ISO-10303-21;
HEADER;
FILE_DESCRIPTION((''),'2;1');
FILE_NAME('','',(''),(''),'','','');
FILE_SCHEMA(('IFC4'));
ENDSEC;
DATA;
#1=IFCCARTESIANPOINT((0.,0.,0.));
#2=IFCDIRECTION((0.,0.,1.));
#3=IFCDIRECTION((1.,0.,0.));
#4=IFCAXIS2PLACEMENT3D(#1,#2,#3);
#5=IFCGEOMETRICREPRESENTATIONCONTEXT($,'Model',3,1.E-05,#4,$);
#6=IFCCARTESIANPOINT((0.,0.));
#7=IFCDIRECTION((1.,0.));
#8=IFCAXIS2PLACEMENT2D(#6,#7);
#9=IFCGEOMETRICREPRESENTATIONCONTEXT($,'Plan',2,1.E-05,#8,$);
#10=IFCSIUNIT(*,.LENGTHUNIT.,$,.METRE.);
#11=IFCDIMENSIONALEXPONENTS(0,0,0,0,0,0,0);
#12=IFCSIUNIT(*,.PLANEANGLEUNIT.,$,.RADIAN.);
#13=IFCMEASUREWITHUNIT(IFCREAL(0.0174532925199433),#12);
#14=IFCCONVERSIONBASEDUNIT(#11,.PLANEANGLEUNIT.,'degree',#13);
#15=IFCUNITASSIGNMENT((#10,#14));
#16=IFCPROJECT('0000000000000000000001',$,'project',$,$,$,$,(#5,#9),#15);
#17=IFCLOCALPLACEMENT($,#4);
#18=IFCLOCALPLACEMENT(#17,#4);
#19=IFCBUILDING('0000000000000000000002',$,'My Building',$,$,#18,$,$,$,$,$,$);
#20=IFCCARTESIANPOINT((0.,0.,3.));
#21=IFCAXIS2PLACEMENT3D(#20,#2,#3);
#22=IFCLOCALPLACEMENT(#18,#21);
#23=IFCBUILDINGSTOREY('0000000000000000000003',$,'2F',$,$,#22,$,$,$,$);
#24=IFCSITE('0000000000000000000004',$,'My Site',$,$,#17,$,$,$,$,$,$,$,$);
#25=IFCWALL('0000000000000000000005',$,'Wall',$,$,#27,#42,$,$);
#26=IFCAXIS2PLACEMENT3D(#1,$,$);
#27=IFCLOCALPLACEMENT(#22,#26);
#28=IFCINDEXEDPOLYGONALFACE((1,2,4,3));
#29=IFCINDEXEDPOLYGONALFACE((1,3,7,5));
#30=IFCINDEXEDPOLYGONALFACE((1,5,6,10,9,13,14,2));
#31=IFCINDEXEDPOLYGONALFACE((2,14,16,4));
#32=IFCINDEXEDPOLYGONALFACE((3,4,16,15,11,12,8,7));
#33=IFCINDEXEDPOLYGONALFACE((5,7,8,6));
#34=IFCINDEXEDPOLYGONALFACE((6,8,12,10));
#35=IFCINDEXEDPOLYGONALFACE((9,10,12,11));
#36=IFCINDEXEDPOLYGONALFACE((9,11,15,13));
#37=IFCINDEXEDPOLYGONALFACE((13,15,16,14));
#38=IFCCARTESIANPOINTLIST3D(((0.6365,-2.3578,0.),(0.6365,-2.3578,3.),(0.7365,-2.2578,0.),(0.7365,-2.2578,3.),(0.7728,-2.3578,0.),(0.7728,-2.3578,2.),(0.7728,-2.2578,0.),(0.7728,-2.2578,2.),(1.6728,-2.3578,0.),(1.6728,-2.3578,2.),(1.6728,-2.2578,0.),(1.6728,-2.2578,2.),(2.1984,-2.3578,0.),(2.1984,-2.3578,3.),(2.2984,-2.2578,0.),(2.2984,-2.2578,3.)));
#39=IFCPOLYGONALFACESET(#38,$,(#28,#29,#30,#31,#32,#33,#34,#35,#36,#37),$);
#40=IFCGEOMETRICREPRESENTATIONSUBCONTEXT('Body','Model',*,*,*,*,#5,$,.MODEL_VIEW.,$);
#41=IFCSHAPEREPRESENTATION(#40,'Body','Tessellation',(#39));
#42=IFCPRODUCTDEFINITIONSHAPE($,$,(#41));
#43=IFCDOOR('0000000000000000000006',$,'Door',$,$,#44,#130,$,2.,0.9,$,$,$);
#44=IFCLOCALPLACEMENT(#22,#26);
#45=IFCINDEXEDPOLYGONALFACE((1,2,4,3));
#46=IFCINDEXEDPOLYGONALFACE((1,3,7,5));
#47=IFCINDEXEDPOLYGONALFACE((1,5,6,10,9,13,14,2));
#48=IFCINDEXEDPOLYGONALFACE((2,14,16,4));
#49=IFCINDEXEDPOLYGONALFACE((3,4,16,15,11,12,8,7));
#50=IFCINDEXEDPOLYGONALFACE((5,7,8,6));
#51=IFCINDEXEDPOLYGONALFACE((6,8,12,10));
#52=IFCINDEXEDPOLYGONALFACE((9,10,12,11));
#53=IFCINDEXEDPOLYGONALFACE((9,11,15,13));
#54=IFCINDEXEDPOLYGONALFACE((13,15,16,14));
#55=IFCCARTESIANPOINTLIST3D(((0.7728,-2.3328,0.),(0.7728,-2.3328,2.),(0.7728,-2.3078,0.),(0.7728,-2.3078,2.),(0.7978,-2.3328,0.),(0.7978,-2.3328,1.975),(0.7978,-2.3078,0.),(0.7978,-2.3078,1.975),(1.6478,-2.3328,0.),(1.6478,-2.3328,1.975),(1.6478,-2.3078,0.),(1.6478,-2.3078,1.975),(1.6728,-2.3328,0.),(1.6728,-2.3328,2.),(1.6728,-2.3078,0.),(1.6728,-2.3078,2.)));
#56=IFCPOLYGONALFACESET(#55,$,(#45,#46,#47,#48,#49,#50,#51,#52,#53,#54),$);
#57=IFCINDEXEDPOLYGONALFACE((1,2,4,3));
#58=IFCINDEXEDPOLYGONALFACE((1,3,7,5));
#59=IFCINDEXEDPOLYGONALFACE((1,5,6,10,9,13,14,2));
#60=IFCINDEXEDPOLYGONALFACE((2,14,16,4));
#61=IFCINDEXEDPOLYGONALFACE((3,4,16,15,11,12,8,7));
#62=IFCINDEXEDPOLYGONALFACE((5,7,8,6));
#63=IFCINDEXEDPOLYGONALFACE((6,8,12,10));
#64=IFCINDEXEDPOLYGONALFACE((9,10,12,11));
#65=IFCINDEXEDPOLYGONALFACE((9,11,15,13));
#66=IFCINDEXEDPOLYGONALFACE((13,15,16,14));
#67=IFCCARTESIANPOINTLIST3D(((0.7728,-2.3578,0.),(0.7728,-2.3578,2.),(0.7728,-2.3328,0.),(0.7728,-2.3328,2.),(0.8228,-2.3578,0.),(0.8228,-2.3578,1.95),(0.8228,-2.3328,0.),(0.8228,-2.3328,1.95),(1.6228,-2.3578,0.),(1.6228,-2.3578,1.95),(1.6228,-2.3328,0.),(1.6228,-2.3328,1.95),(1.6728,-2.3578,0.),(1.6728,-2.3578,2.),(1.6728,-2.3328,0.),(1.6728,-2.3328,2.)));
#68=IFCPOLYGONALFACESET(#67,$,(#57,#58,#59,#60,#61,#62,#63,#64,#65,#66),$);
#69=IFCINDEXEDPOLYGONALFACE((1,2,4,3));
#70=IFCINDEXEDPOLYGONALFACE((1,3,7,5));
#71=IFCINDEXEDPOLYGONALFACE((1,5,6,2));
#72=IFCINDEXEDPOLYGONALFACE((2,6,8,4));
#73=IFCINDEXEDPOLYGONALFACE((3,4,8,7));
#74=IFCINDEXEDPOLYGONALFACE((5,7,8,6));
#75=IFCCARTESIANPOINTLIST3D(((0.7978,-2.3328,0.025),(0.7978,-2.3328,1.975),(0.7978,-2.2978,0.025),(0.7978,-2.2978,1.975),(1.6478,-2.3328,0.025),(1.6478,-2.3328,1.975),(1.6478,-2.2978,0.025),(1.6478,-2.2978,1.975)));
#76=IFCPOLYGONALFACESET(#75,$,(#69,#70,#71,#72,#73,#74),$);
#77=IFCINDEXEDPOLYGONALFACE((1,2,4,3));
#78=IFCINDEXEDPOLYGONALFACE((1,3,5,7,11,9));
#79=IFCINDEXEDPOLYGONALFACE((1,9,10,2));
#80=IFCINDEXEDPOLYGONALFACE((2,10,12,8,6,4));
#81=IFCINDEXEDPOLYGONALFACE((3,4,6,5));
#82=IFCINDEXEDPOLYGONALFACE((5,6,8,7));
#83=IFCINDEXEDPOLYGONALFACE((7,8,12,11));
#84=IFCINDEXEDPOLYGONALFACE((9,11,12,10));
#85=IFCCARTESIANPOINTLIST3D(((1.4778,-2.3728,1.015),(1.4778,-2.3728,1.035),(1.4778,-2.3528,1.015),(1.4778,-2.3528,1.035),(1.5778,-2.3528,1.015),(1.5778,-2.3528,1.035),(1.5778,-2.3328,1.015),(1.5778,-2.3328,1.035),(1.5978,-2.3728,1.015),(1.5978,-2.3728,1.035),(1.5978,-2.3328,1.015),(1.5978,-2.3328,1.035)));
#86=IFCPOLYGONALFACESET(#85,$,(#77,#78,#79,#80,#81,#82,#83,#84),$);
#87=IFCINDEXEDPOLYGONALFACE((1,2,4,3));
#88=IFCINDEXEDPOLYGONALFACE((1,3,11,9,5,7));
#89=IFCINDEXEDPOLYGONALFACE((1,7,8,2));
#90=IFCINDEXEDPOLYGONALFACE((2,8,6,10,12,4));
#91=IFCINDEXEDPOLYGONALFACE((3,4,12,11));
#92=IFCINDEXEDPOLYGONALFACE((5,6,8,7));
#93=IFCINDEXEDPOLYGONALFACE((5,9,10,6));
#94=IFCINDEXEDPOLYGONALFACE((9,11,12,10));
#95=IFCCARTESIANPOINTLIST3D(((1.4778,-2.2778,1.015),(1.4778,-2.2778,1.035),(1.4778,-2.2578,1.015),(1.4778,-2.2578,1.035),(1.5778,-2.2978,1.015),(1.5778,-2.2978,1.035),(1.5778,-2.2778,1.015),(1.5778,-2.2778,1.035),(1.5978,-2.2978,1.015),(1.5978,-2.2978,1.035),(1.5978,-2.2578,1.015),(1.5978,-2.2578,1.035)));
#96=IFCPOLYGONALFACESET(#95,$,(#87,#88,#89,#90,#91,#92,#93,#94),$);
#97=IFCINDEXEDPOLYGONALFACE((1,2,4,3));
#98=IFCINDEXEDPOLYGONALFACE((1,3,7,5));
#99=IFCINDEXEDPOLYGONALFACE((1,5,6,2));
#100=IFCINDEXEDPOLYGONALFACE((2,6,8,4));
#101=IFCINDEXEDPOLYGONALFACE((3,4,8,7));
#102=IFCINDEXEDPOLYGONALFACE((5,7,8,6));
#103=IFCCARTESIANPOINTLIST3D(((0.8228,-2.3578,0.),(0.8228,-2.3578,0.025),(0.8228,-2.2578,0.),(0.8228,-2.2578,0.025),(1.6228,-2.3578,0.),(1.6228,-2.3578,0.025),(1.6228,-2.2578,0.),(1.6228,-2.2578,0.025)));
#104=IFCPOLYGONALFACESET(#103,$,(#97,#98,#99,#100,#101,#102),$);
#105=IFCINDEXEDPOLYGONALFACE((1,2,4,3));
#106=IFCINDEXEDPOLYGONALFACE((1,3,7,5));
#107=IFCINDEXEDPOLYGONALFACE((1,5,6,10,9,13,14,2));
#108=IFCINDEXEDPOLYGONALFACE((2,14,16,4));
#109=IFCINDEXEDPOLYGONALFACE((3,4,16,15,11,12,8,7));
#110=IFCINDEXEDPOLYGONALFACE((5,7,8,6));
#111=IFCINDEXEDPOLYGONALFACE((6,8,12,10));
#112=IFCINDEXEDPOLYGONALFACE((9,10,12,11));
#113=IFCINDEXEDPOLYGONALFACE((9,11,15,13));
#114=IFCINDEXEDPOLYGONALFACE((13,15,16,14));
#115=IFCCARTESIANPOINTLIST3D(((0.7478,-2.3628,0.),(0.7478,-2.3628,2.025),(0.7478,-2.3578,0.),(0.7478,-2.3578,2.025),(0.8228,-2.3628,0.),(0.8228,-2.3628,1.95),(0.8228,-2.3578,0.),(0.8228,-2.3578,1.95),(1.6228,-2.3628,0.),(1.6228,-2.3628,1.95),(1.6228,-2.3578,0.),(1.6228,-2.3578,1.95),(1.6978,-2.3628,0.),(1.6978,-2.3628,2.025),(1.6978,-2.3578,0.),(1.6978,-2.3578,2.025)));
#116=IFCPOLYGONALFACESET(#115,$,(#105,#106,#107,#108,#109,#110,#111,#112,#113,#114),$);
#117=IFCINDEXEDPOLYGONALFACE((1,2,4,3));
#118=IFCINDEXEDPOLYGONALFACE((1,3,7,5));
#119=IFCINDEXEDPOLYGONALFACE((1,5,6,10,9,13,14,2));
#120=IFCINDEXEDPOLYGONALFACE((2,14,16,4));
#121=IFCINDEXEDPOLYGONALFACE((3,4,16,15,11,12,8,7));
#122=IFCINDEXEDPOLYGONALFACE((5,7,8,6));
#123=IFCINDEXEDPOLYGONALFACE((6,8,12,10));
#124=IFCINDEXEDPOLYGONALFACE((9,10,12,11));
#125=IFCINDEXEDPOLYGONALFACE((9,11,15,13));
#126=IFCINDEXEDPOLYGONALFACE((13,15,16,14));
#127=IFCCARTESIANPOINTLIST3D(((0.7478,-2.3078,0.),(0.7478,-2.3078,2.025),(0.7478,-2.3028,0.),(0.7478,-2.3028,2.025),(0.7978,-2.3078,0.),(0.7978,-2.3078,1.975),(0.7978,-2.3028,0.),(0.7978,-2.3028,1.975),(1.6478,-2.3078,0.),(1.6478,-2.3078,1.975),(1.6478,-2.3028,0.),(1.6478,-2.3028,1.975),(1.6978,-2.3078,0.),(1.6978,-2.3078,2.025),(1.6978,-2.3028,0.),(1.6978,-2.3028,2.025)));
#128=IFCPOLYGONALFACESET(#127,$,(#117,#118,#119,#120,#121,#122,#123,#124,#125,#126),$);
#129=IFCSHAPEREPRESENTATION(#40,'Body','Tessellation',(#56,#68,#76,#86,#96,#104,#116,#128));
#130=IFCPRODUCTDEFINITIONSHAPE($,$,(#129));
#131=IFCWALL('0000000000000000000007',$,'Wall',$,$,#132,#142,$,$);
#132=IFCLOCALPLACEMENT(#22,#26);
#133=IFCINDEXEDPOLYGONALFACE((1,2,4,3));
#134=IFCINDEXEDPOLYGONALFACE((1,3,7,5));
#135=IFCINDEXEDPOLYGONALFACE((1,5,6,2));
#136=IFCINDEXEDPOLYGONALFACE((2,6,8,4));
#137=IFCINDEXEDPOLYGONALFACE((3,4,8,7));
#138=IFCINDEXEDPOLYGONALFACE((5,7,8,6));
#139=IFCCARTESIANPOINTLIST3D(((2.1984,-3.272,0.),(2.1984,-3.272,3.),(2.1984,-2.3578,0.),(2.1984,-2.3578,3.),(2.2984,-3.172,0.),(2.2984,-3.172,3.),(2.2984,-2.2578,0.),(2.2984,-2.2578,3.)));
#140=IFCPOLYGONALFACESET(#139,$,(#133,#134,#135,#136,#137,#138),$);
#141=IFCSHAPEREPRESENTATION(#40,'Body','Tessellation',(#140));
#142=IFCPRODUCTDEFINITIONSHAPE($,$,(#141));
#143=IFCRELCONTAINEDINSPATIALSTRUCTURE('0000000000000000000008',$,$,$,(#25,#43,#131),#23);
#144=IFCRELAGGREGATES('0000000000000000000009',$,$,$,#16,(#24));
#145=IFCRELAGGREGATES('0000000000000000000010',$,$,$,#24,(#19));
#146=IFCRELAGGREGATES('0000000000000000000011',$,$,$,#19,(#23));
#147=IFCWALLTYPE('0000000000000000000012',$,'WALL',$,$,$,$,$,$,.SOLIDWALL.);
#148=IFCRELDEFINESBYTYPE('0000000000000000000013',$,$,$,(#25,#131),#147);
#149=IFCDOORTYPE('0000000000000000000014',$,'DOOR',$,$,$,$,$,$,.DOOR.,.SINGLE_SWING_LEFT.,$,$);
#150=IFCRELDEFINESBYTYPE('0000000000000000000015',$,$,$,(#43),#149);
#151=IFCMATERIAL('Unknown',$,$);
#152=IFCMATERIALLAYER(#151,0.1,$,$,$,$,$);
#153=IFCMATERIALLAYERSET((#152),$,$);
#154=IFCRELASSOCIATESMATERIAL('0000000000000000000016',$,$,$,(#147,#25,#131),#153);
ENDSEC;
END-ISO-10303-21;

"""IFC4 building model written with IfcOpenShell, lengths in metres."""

from ifc_helpers import new_model, entity, si_unit, converted_unit, frame, origin_with_axes, origin_2d_with_axis, place, context, subcontext, project, spatial, line, indexed_curve, outline, extrude, shape, source, transform, mapped, material, layer, layer_set, layer_usage, type_object, type_shapes, element, fill, save


model = new_model("IFC4")

# Units and contexts
model_context = context("Model", 3, precision=1e-05, world=origin_with_axes())
plan_context = context("Plan", 2, precision=1e-05, world=origin_2d_with_axis())
body_context_1 = subcontext(model_context, "Body", "Model", "MODEL_VIEW")
body_context_2 = subcontext(plan_context, "Body", "Plan", "PLAN_VIEW")
ifc_project = project(units=[si_unit("LENGTHUNIT", "METRE"), converted_unit("PLANEANGLEUNIT", "degree", entity("IfcReal", 0.0174532925199433), si_unit("PLANEANGLEUNIT", "RADIAN"), dimensions=[0, 0, 0, 0, 0, 0, 0])], contexts=[model_context, plan_context])

# Site, building, storey
site_placement = place(None, origin_with_axes())
site = spatial("IfcSite", under=ifc_project, at=site_placement, Name="My Site")
building_placement = place(site_placement, origin_with_axes())
building = spatial("IfcBuilding", under=site, at=building_placement, Name="My Building")
storey_placement = place(building_placement, frame((0.0, 0.0, 3.0), z_axis=(0.0, 0.0, 1.0), x_axis=(1.0, 0.0, 0.0)))
storey = spatial("IfcBuildingStorey", under=building, at=storey_placement, Name="2F")

# Shared definitions
ifc_material = material(Name="Unknown")

# Shared definitions
ifc_layer_1 = layer(ifc_material, 0.1)
ifc_layer_set_1 = layer_set([ifc_layer_1])
wall_type_1 = type_object("IfcWallType", Name="WALL", PredefinedType="SOLIDWALL", material=ifc_layer_set_1)

# Wall, opening, door
ifc_layer_usage_1 = layer_usage(ifc_layer_set_1, "AXIS2", "POSITIVE", 0.0)
wall_1_placement = place(storey_placement, frame((0.6365, -2.3578, 0.0), z_axis=(0.0, 0.0, 1.0), x_axis=(1.0, 0.0, 0.0)))
wall_1 = element("IfcWall", 1, at=wall_1_placement, inside=storey, type_object=wall_type_1, material=ifc_layer_usage_1, Name="Wall", context=body_context_1, shape_type="SweptSolid", body=[
    extrude(outline(indexed_curve([(0.0, 0.0), (0.1, 0.1), (1.6619, 0.1), (1.5619, 0.0)], segments=[line(1, 2, 3, 4, 1)])), origin_with_axes(), (0.0, 0.0, 1.0), 3.0),
])
shared_shape_1 = source(origin_with_axes(), body_context_1, "Body", "SweptSolid", [
    extrude(outline(indexed_curve([(0.0, 0.0), (0.9, 0.0), (0.9, 2.0), (0.0, 2.0)], segments=[line(1, 2, 3, 4, 1)])), frame((0.0, -0.6, 0.0), z_axis=(0.0, -1.0, 0.0), x_axis=(1.0, 0.0, 0.0)), (0.0, 0.0, -1.0), 1.2),
])
opening_1_placement = place(wall_1_placement, frame((0.1363, 0.0, 0.0), z_axis=(0.0, 0.0, 1.0), x_axis=(1.0, 0.0, 0.0)))
opening_1 = element("IfcOpeningElement", 2, at=opening_1_placement, cuts=wall_1, PredefinedType="OPENING", context=body_context_1, shape_type="MappedRepresentation", body=[
    mapped(shared_shape_1, transform((0.0, 0.0, 0.0), x_axis=(1.0, 0.0, 0.0), y_axis=(0.0, 1.0, 0.0), z_axis=(0.0, 0.0, 1.0), scale=1.0)),
])
door_type = type_object("IfcDoorType", Name="DOOR", OperationType="SINGLE_SWING_LEFT", PredefinedType="DOOR")
shared_shape_2 = source(origin_with_axes(), body_context_1, "Body", "SweptSolid", [
    extrude(outline(indexed_curve([(0.0, 0.0), (0.0, 2.0), (0.9, 2.0), (0.9, 0.0), (0.875, 0.0), (0.875, 1.975), (0.025, 1.975), (0.025, 0.0)], segments=[line(1, 2, 3, 4, 5, 6, 7, 8, 1)])), frame((0.0, 0.025, 0.0), z_axis=(0.0, -1.0, 0.0), x_axis=(1.0, 0.0, 0.0)), (0.0, 0.0, -1.0), 0.025),
    extrude(outline(indexed_curve([(0.0, 0.0), (0.0, 2.0), (0.9, 2.0), (0.9, 0.0), (0.85, 0.0), (0.85, 1.95), (0.05, 1.95), (0.05, 0.0)], segments=[line(1, 2, 3, 4, 5, 6, 7, 8, 1)])), frame((0.0, 0.0, 0.0), z_axis=(0.0, -1.0, 0.0), x_axis=(1.0, 0.0, 0.0)), (0.0, 0.0, -1.0), 0.025),
    extrude(outline(indexed_curve([(0.0, 0.0), (0.85, 0.0), (0.85, 0.035), (0.0, 0.035)], segments=[line(1, 2, 3, 4, 1)])), frame((0.025, 0.025, 0.025), z_axis=(0.0, 0.0, 1.0), x_axis=(1.0, 0.0, 0.0)), (0.0, 0.0, 1.0), 1.95),
    extrude(outline(indexed_curve([(0.0, 0.0), (0.0, -0.04), (-0.12, -0.04), (-0.12, -0.02), (-0.02, -0.02), (-0.02, 0.0)], segments=[line(1, 2, 3, 4, 5, 6, 1)])), frame((0.825, 0.025, 1.015), z_axis=(0.0, 0.0, 1.0), x_axis=(1.0, 0.0, 0.0)), (0.0, 0.0, 1.0), 0.02),
    extrude(outline(indexed_curve([(0.0, 0.0), (0.0, 0.04), (-0.12, 0.04), (-0.12, 0.02), (-0.02, 0.02), (-0.02, 0.0)], segments=[line(1, 2, 3, 4, 5, 6, 1)])), frame((0.825, 0.06, 1.015), z_axis=(0.0, 0.0, 1.0), x_axis=(1.0, 0.0, 0.0)), (0.0, 0.0, 1.0), 0.02),
    extrude(outline(indexed_curve([(0.0, 0.0), (0.8, 0.0), (0.8, 0.1), (0.0, 0.1)], segments=[line(1, 2, 3, 4, 1)])), frame((0.05, 0.0, 0.0), z_axis=(0.0, 0.0, 1.0), x_axis=(1.0, 0.0, 0.0)), (0.0, 0.0, 1.0), 0.025),
    extrude(outline(indexed_curve([(0.0, 0.0), (0.0, 2.025), (0.95, 2.025), (0.95, 0.0), (0.875, 0.0), (0.875, 1.95), (0.075, 1.95), (0.075, 0.0)], segments=[line(1, 2, 3, 4, 5, 6, 7, 8, 1)])), frame((-0.025, -0.005, 0.0), z_axis=(0.0, -1.0, 0.0), x_axis=(1.0, 0.0, 0.0)), (0.0, 0.0, -1.0), 0.005),
    extrude(outline(indexed_curve([(0.0, 0.0), (0.0, 2.025), (0.95, 2.025), (0.95, 0.0), (0.9, 0.0), (0.9, 1.975), (0.05, 1.975), (0.05, 0.0)], segments=[line(1, 2, 3, 4, 5, 6, 7, 8, 1)])), frame((-0.025, 0.05, 0.0), z_axis=(0.0, -1.0, 0.0), x_axis=(1.0, 0.0, 0.0)), (0.0, 0.0, -1.0), 0.005),
])
shared_shape_3 = source(origin_with_axes(), body_context_2, "Body", "Curve2D", [
    entity("IfcIndexedPolyCurve", entity("IfcCartesianPointList2D", [[0.0, 0.0], [0.0, 0.05], [0.025, 0.05], [0.025, 0.025], [0.05, 0.025], [0.05, 0.0]]), [entity("IfcLineIndex", [1, 2, 3, 4, 5, 6, 1])]),
    entity("IfcIndexedPolyCurve", entity("IfcCartesianPointList2D", [[0.9, 0.0], [0.9, 0.05], [0.875, 0.05], [0.875, 0.025], [0.85, 0.025], [0.85, 0.0]]), [entity("IfcLineIndex", [1, 2, 3, 4, 5, 6, 1])]),
    entity("IfcTrimmedCurve", entity("IfcEllipse", entity("IfcAxis2Placement2D", entity("IfcCartesianPoint", [0.06, 0.05]), entity("IfcDirection", [1.0, 0.0])), 0.815, 0.85), [entity("IfcCartesianPoint", [0.875, 0.05])], [entity("IfcCartesianPoint", [0.06, 0.9])], True, "CARTESIAN"),
    entity("IfcIndexedPolyCurve", entity("IfcCartesianPointList2D", [[0.025, 0.05], [0.06, 0.05], [0.06, 0.9], [0.025, 0.9]]), [entity("IfcLineIndex", [1, 2, 3, 4, 1])]),
])
type_shapes(door_type, [shared_shape_2, shared_shape_3])
door_1_placement = place(opening_1_placement, origin_with_axes())
door_1 = element("IfcDoor", 3, at=door_1_placement, inside=storey, type_object=door_type, Name="Door", OverallHeight=2.0, OverallWidth=0.9, shapes=[
    shape(body_context_1, "Body", "MappedRepresentation", [mapped(shared_shape_2, transform((0.0, 0.0, 0.0), x_axis=(1.0, 0.0, 0.0), y_axis=(0.0, 1.0, 0.0), z_axis=(0.0, 0.0, 1.0), scale=1.0))]),
    shape(body_context_2, "Body", "MappedRepresentation", [mapped(shared_shape_3, transform((0.0, 0.0, 0.0), x_axis=(1.0, 0.0, 0.0), y_axis=(0.0, 1.0, 0.0), z_axis=(0.0, 0.0, 1.0), scale=1.0))]),
])
fill(opening_1, door_1)

# Wall
ifc_layer_usage_2 = layer_usage(ifc_layer_set_1, "AXIS2", "POSITIVE", 0.0)
wall_2_placement = place(storey_placement, frame((2.1984, -2.3578, 0.0), z_axis=(0.0, 0.0, 1.0), x_axis=(0.0, -1.0, 0.0)))
element("IfcWall", 4, at=wall_2_placement, inside=storey, type_object=wall_type_1, material=ifc_layer_usage_2, Name="Wall", context=body_context_1, shape_type="SweptSolid", body=[
    extrude(outline(indexed_curve([(0.0, 0.0), (-0.1, 0.1), (0.8142, 0.1), (0.9142, 0.0)], segments=[line(1, 2, 3, 4, 1)])), origin_with_axes(), (0.0, 0.0, 1.0), 3.0),
])

save(model, "model.ifc")
